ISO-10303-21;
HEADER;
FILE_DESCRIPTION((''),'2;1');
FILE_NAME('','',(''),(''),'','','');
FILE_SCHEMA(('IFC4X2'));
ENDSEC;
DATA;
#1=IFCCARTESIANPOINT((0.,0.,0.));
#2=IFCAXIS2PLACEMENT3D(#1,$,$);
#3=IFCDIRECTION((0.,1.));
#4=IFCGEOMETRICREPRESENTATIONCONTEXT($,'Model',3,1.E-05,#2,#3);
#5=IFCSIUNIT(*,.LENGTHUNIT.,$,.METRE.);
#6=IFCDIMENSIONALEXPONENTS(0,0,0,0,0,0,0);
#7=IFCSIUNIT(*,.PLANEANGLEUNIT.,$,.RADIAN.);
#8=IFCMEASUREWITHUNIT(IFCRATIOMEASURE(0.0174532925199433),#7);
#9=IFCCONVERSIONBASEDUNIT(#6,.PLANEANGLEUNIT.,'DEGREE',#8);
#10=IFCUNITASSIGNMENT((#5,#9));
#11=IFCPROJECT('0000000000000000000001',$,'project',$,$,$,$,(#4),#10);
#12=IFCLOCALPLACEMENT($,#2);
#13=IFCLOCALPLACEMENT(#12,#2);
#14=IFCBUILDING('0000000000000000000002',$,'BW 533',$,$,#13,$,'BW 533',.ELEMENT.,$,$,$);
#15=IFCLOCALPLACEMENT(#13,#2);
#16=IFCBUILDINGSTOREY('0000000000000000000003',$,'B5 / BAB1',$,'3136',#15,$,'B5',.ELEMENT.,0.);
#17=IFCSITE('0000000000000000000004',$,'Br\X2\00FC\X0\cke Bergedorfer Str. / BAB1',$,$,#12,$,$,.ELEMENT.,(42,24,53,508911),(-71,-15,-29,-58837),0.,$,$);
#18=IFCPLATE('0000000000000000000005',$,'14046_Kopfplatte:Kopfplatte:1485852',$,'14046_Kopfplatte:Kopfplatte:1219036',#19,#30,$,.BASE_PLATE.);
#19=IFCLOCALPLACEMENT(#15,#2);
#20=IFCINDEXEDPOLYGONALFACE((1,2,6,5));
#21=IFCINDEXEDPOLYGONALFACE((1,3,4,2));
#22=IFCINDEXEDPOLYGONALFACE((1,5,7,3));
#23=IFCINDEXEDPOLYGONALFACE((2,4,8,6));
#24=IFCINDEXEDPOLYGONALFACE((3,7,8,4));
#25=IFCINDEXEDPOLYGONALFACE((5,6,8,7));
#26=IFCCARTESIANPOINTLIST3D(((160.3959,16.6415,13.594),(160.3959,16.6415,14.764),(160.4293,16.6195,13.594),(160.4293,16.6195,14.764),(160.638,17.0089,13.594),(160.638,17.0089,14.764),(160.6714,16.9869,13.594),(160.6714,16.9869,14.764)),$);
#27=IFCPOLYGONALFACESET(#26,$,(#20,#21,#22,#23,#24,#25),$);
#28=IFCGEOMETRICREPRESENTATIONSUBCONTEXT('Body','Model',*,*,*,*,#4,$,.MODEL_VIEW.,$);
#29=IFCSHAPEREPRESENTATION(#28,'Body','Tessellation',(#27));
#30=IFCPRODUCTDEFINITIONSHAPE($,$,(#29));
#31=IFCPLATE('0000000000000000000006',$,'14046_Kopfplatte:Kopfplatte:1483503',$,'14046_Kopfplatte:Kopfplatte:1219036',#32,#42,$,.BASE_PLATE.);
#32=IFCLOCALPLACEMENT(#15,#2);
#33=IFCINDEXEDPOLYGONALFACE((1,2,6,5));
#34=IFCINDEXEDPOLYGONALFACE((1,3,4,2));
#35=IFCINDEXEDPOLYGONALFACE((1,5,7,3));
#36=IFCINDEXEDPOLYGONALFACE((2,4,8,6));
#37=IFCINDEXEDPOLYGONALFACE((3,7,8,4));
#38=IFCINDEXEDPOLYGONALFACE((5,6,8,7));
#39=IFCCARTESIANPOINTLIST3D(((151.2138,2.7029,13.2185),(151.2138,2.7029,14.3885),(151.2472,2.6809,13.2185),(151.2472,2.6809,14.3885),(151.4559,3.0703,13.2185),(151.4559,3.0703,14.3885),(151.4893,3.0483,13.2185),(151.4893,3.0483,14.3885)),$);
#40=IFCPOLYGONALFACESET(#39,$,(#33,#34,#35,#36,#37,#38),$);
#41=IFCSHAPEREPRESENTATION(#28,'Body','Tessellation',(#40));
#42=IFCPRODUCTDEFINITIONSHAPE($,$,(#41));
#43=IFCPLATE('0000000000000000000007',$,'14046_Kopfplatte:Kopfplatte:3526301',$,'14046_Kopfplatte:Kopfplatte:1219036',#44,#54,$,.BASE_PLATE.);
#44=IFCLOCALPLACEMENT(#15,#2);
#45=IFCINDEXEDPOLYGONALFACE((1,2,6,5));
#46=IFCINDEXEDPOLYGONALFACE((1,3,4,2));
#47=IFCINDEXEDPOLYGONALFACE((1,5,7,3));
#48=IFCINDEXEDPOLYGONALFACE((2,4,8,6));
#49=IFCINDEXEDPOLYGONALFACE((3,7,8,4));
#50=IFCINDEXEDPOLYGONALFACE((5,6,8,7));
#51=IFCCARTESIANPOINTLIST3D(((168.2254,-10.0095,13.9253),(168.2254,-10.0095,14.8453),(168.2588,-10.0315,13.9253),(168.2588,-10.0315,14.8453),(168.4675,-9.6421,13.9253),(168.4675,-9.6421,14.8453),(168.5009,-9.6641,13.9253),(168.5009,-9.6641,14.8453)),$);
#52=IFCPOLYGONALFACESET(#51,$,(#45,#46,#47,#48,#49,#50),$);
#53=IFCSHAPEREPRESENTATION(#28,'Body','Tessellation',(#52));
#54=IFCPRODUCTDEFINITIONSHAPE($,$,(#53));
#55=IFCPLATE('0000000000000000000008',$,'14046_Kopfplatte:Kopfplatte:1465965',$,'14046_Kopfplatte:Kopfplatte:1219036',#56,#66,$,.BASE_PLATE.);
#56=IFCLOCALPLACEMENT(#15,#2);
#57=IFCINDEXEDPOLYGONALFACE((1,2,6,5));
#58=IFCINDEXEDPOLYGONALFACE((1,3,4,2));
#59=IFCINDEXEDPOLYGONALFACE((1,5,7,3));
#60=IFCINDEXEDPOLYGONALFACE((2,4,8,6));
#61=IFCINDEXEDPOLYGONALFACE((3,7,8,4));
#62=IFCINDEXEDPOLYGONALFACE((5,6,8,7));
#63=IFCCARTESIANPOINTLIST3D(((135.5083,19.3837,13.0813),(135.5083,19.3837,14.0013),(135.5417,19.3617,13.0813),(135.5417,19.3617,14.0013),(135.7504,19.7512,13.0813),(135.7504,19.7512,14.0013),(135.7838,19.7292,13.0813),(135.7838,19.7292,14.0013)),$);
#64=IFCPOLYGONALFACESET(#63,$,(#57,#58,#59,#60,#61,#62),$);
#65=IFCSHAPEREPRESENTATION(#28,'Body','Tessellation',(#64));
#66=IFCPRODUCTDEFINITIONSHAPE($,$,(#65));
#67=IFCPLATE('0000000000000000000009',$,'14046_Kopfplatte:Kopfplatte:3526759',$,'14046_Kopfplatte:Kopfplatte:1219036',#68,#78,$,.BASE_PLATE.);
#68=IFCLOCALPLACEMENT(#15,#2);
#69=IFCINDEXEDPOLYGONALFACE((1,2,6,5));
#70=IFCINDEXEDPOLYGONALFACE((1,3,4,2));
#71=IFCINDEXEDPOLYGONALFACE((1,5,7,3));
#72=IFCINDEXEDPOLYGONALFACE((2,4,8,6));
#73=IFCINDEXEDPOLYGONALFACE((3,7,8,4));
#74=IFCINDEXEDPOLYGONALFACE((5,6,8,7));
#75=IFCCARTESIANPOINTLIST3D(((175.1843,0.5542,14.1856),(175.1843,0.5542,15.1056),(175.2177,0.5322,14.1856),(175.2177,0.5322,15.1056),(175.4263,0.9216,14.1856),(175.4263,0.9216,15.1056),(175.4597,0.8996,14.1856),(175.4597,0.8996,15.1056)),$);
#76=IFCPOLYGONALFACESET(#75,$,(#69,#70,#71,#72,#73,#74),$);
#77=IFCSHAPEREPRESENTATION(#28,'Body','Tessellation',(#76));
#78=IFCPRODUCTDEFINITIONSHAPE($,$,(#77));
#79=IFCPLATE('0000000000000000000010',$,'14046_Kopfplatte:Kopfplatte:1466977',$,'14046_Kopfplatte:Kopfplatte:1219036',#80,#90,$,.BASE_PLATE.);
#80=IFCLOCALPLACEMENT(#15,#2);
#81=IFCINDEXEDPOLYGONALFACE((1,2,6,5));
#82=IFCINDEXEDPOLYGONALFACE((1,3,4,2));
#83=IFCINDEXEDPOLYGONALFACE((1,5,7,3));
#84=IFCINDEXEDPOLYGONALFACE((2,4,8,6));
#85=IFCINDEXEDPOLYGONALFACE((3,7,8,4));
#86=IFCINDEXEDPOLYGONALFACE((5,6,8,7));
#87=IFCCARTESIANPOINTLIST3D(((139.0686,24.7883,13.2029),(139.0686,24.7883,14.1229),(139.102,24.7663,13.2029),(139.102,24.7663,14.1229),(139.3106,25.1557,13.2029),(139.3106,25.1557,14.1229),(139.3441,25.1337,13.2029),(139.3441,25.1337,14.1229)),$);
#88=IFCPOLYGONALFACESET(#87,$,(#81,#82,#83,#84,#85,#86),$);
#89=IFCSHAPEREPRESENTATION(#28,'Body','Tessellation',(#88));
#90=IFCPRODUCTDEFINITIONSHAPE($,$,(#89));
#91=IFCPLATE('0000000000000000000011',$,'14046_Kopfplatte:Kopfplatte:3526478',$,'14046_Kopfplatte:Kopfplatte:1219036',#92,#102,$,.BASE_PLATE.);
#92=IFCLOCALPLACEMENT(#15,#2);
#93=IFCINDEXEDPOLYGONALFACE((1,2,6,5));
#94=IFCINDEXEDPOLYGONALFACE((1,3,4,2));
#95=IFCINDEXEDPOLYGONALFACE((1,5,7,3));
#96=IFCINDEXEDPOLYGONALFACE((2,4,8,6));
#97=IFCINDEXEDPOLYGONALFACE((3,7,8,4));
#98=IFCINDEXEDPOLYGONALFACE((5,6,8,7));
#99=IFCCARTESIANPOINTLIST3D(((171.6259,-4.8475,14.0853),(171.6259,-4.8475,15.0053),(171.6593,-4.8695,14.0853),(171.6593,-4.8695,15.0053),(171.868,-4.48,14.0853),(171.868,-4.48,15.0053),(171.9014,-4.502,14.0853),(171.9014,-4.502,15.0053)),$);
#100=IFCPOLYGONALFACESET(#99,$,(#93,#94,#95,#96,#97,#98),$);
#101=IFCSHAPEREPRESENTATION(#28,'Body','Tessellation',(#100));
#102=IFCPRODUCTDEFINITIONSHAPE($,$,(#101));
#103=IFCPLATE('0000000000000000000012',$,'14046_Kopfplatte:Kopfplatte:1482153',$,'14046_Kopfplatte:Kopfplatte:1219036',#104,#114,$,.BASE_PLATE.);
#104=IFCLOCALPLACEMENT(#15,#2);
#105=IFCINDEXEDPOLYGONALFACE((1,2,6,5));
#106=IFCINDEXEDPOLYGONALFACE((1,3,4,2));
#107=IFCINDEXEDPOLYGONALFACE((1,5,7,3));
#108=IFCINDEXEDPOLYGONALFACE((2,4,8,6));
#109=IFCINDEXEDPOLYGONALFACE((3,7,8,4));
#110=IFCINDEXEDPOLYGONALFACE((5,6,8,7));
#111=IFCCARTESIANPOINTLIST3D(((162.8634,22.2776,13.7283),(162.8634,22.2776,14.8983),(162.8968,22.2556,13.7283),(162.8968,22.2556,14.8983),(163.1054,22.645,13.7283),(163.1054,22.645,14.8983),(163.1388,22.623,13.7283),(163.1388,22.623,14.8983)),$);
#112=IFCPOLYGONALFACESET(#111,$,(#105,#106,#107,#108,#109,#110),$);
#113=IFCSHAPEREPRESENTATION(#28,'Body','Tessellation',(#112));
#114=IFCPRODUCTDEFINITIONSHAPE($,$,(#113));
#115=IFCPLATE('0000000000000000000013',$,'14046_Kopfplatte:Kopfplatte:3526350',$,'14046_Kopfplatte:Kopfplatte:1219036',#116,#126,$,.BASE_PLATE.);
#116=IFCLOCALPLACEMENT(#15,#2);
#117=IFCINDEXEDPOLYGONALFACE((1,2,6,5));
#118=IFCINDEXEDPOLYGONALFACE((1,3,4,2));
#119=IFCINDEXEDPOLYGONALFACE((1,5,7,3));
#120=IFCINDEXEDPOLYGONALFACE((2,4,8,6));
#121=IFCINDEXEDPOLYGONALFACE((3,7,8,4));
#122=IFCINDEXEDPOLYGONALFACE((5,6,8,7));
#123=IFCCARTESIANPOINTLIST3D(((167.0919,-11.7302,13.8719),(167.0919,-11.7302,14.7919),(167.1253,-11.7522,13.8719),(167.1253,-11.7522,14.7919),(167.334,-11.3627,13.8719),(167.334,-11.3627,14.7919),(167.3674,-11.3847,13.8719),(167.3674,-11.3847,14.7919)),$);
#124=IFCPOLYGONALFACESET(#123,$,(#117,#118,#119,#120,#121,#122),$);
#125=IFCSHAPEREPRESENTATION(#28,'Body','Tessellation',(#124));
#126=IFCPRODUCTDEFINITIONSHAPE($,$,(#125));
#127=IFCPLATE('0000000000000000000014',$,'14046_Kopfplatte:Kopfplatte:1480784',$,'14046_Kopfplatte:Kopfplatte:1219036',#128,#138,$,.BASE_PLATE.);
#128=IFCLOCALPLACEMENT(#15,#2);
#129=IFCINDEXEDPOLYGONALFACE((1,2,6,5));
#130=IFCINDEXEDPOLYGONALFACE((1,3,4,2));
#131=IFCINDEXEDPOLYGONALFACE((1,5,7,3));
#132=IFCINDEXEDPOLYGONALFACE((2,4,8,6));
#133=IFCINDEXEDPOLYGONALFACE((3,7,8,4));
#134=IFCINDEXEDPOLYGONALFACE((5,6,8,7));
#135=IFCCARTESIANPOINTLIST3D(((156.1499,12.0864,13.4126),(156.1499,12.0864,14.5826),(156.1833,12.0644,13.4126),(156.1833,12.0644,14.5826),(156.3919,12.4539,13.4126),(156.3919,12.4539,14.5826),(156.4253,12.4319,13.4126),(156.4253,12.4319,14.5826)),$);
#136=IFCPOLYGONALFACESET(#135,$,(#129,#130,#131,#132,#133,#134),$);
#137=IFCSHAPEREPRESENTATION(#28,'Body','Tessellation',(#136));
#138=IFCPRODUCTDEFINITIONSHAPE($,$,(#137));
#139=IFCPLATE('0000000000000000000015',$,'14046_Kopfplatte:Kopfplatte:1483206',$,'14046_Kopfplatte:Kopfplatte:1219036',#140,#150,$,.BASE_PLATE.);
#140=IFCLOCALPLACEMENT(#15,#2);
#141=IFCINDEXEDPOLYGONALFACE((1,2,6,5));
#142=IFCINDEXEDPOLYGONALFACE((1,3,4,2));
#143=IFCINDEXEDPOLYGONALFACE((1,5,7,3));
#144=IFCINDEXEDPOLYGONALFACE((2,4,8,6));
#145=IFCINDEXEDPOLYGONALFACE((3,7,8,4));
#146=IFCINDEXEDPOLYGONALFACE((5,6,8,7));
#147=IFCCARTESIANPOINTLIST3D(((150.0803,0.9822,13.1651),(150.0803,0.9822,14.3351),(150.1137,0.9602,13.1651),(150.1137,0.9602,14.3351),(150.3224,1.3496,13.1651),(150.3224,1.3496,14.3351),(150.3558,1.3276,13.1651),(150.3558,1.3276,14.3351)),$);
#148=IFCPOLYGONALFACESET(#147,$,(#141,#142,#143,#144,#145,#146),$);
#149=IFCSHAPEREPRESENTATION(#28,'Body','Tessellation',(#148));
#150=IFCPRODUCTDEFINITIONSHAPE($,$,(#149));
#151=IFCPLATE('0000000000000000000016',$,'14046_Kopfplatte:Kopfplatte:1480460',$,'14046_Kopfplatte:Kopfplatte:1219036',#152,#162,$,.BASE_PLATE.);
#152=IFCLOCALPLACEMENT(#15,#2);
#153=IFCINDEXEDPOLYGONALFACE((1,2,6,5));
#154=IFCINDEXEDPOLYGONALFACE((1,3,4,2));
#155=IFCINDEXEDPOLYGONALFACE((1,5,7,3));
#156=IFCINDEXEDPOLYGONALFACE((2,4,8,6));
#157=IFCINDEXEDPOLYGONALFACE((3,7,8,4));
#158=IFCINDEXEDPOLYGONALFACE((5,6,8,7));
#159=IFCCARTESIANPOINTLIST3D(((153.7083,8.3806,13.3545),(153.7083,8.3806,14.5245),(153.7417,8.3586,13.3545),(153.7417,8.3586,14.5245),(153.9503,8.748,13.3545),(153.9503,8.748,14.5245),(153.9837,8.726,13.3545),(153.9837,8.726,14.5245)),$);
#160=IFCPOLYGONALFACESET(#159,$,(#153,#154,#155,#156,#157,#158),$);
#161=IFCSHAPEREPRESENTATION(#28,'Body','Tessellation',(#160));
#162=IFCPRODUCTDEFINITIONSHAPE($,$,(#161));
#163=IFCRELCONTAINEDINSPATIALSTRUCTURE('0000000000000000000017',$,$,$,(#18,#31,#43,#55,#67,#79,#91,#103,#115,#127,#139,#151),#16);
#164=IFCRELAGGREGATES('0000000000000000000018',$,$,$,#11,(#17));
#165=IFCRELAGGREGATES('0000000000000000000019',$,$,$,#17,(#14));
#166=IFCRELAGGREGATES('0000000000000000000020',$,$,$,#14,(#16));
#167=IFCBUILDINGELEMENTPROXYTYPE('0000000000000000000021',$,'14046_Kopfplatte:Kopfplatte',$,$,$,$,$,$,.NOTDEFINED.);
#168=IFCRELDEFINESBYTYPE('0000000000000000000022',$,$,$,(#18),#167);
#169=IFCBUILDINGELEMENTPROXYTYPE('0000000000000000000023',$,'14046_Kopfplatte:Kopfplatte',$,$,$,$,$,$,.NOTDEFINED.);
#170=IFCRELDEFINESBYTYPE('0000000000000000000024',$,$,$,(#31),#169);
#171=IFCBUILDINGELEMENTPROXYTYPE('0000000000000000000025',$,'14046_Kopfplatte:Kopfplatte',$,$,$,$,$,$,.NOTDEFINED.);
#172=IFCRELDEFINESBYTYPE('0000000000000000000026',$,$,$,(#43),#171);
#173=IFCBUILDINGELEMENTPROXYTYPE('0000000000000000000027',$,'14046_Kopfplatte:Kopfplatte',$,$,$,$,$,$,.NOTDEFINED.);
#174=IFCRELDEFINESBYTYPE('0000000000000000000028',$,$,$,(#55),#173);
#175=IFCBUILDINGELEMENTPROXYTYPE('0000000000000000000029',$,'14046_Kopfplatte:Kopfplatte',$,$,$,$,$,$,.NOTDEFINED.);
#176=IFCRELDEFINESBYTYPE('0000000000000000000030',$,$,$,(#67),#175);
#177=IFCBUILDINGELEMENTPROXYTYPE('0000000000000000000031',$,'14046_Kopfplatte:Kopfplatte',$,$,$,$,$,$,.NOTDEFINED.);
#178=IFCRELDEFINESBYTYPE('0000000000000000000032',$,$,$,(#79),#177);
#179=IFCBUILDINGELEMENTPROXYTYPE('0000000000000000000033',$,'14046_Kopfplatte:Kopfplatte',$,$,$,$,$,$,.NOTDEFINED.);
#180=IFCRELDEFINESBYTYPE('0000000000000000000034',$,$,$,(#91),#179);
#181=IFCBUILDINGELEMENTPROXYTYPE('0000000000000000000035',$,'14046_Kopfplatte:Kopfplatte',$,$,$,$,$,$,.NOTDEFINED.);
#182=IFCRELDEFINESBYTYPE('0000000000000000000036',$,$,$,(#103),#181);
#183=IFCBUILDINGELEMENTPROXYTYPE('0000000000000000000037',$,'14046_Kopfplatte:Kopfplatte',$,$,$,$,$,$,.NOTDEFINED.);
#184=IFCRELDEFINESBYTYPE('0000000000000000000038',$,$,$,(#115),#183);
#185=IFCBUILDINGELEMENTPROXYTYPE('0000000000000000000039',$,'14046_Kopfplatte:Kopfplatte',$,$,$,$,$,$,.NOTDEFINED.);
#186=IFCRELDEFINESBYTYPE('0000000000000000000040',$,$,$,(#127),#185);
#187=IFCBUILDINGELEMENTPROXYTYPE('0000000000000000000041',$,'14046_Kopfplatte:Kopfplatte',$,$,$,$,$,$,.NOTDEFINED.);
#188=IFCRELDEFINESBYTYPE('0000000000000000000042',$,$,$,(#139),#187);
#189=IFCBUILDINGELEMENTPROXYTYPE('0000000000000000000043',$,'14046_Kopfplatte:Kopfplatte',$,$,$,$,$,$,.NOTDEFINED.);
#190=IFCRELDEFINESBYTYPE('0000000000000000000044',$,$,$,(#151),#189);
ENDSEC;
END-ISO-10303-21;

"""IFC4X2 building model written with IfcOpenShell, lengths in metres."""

from ifc_helpers import new_model, entity, si_unit, converted_unit, direction, frame, frame_2d, origin, origin_2d_with_axis, place, context, subcontext, project, spatial, rectangle, extrude, source, transform, mapped, type_object, type_shapes, element, save


model = new_model("IFC4X2")

# Units and contexts
model_context = context("Model", 3, precision=1e-05, world=origin(), true_north=direction((0.0, 1.0)))
body_context = subcontext(model_context, "Body", "Model", "MODEL_VIEW")
ifc_project = project(units=[si_unit("LENGTHUNIT", "METRE"), converted_unit("PLANEANGLEUNIT", "DEGREE", entity("IfcRatioMeasure", 0.0174532925199433), si_unit("PLANEANGLEUNIT", "RADIAN"), dimensions=[0, 0, 0, 0, 0, 0, 0])], contexts=[model_context])

# Site, building, storey
site_placement = place(None, origin())
site = spatial("IfcSite", under=ifc_project, at=site_placement, Name="Brücke Bergedorfer Str. / BAB1", CompositionType="ELEMENT", RefLatitude=(42, 24, 53, 508911), RefLongitude=(-71, -15, -29, -58837), RefElevation=0.0)
building_placement = place(site_placement, origin())
building = spatial("IfcBuilding", under=site, at=building_placement, Name="BW 533", LongName="BW 533", CompositionType="ELEMENT")
storey_placement = place(building_placement, origin())
storey = spatial("IfcBuildingStorey", under=building, at=storey_placement, Name="B5 / BAB1", ObjectType="3136", LongName="B5", CompositionType="ELEMENT", Elevation=0.0)

# Plates
building_element_proxy_type_1 = type_object("IfcBuildingElementProxyType", Name="14046_Kopfplatte:Kopfplatte", PredefinedType="NOTDEFINED")
shared_shape_1 = source(origin(), body_context, "Body", "SweptSolid", [
    extrude(rectangle(XDim=0.04, YDim=0.44, at=frame_2d((0.0, 0.0), x_axis=(1.0, 0.0))), frame((160.5336, 16.8142, 13.594), z_axis=(0.0, 0.0, 1.0), x_axis=(-0.835088, 0.550116, 0.0)), (0.0, 0.0, 1.0), 1.17),
])
type_shapes(building_element_proxy_type_1, [shared_shape_1])
plate_1_placement = place(storey_placement, origin())
element("IfcPlate", 1, at=plate_1_placement, inside=storey, type_object=building_element_proxy_type_1, Name="14046_Kopfplatte:Kopfplatte:1485852", ObjectType="14046_Kopfplatte:Kopfplatte:1219036", PredefinedType="BASE_PLATE", context=body_context, shape_type="MappedRepresentation", body=[
    mapped(shared_shape_1, transform((0.0, 0.0, 0.0), scale=1.0)),
])
building_element_proxy_type_2 = type_object("IfcBuildingElementProxyType", Name="14046_Kopfplatte:Kopfplatte", PredefinedType="NOTDEFINED")
shared_shape_2 = source(origin(), body_context, "Body", "SweptSolid", [
    extrude(rectangle(XDim=0.04, YDim=0.44, at=frame_2d((0.0, 0.0), x_axis=(1.0, 0.0))), frame((151.3516, 2.8756, 13.2185), z_axis=(0.0, 0.0, 1.0), x_axis=(-0.835088, 0.550116, 0.0)), (0.0, 0.0, 1.0), 1.17),
])
type_shapes(building_element_proxy_type_2, [shared_shape_2])
plate_2_placement = place(storey_placement, origin())
element("IfcPlate", 2, at=plate_2_placement, inside=storey, type_object=building_element_proxy_type_2, Name="14046_Kopfplatte:Kopfplatte:1483503", ObjectType="14046_Kopfplatte:Kopfplatte:1219036", PredefinedType="BASE_PLATE", context=body_context, shape_type="MappedRepresentation", body=[
    mapped(shared_shape_2, transform((0.0, 0.0, 0.0), scale=1.0)),
])
building_element_proxy_type_3 = type_object("IfcBuildingElementProxyType", Name="14046_Kopfplatte:Kopfplatte", PredefinedType="NOTDEFINED")
shared_shape_3 = source(origin(), body_context, "Body", "SweptSolid", [
    extrude(rectangle(XDim=0.04, YDim=0.44, at=frame_2d((0.0, 0.0), x_axis=(1.0, 0.0))), frame((168.3631, -9.8368, 13.9253), z_axis=(0.0, 0.0, 1.0), x_axis=(0.835088, -0.550116, 0.0)), (0.0, 0.0, 1.0), 0.92),
])
type_shapes(building_element_proxy_type_3, [shared_shape_3])
plate_3_placement = place(storey_placement, origin())
element("IfcPlate", 3, at=plate_3_placement, inside=storey, type_object=building_element_proxy_type_3, Name="14046_Kopfplatte:Kopfplatte:3526301", ObjectType="14046_Kopfplatte:Kopfplatte:1219036", PredefinedType="BASE_PLATE", context=body_context, shape_type="MappedRepresentation", body=[
    mapped(shared_shape_3, transform((0.0, 0.0, 0.0), scale=1.0)),
])
building_element_proxy_type_4 = type_object("IfcBuildingElementProxyType", Name="14046_Kopfplatte:Kopfplatte", PredefinedType="NOTDEFINED")
shared_shape_4 = source(origin(), body_context, "Body", "SweptSolid", [
    extrude(rectangle(XDim=0.04, YDim=0.44, at=frame_2d((0.0, 0.0), x_axis=(1.0, 0.0))), frame((135.6461, 19.5565, 13.0813), z_axis=(0.0, 0.0, 1.0), x_axis=(-0.835088, 0.550116, 0.0)), (0.0, 0.0, 1.0), 0.92),
])
type_shapes(building_element_proxy_type_4, [shared_shape_4])
plate_4_placement = place(storey_placement, origin())
element("IfcPlate", 4, at=plate_4_placement, inside=storey, type_object=building_element_proxy_type_4, Name="14046_Kopfplatte:Kopfplatte:1465965", ObjectType="14046_Kopfplatte:Kopfplatte:1219036", PredefinedType="BASE_PLATE", context=body_context, shape_type="MappedRepresentation", body=[
    mapped(shared_shape_4, transform((0.0, 0.0, 0.0), scale=1.0)),
])
building_element_proxy_type_5 = type_object("IfcBuildingElementProxyType", Name="14046_Kopfplatte:Kopfplatte", PredefinedType="NOTDEFINED")
shared_shape_5 = source(origin(), body_context, "Body", "SweptSolid", [
    extrude(rectangle(XDim=0.04, YDim=0.44, at=frame_2d((0.0, 0.0), x_axis=(1.0, 0.0))), frame((175.322, 0.7269, 14.1856), z_axis=(0.0, 0.0, 1.0), x_axis=(0.835088, -0.550116, 0.0)), (0.0, 0.0, 1.0), 0.92),
])
type_shapes(building_element_proxy_type_5, [shared_shape_5])
plate_5_placement = place(storey_placement, origin())
element("IfcPlate", 5, at=plate_5_placement, inside=storey, type_object=building_element_proxy_type_5, Name="14046_Kopfplatte:Kopfplatte:3526759", ObjectType="14046_Kopfplatte:Kopfplatte:1219036", PredefinedType="BASE_PLATE", context=body_context, shape_type="MappedRepresentation", body=[
    mapped(shared_shape_5, transform((0.0, 0.0, 0.0), scale=1.0)),
])
building_element_proxy_type_6 = type_object("IfcBuildingElementProxyType", Name="14046_Kopfplatte:Kopfplatte", PredefinedType="NOTDEFINED")
shared_shape_6 = source(origin(), body_context, "Body", "SweptSolid", [
    extrude(rectangle(XDim=0.04, YDim=0.44, at=frame_2d((0.0, 0.0), x_axis=(1.0, 0.0))), frame((139.2063, 24.961, 13.2029), z_axis=(0.0, 0.0, 1.0), x_axis=(-0.835088, 0.550116, 0.0)), (0.0, 0.0, 1.0), 0.92),
])
type_shapes(building_element_proxy_type_6, [shared_shape_6])
plate_6_placement = place(storey_placement, origin())
element("IfcPlate", 6, at=plate_6_placement, inside=storey, type_object=building_element_proxy_type_6, Name="14046_Kopfplatte:Kopfplatte:1466977", ObjectType="14046_Kopfplatte:Kopfplatte:1219036", PredefinedType="BASE_PLATE", context=body_context, shape_type="MappedRepresentation", body=[
    mapped(shared_shape_6, transform((0.0, 0.0, 0.0), scale=1.0)),
])
building_element_proxy_type_7 = type_object("IfcBuildingElementProxyType", Name="14046_Kopfplatte:Kopfplatte", PredefinedType="NOTDEFINED")
shared_shape_7 = source(origin(), body_context, "Body", "SweptSolid", [
    extrude(rectangle(XDim=0.04, YDim=0.44, at=frame_2d((0.0, 0.0), x_axis=(1.0, 0.0))), frame((171.7636, -4.6748, 14.0853), z_axis=(0.0, 0.0, 1.0), x_axis=(0.835088, -0.550116, 0.0)), (0.0, 0.0, 1.0), 0.92),
])
type_shapes(building_element_proxy_type_7, [shared_shape_7])
plate_7_placement = place(storey_placement, origin())
element("IfcPlate", 7, at=plate_7_placement, inside=storey, type_object=building_element_proxy_type_7, Name="14046_Kopfplatte:Kopfplatte:3526478", ObjectType="14046_Kopfplatte:Kopfplatte:1219036", PredefinedType="BASE_PLATE", context=body_context, shape_type="MappedRepresentation", body=[
    mapped(shared_shape_7, transform((0.0, 0.0, 0.0), scale=1.0)),
])
building_element_proxy_type_8 = type_object("IfcBuildingElementProxyType", Name="14046_Kopfplatte:Kopfplatte", PredefinedType="NOTDEFINED")
shared_shape_8 = source(origin(), body_context, "Body", "SweptSolid", [
    extrude(rectangle(XDim=0.04, YDim=0.44, at=frame_2d((0.0, 0.0), x_axis=(1.0, 0.0))), frame((163.0011, 22.4503, 13.7283), z_axis=(0.0, 0.0, 1.0), x_axis=(0.835088, -0.550116, 0.0)), (0.0, 0.0, 1.0), 1.17),
])
type_shapes(building_element_proxy_type_8, [shared_shape_8])
plate_8_placement = place(storey_placement, origin())
element("IfcPlate", 8, at=plate_8_placement, inside=storey, type_object=building_element_proxy_type_8, Name="14046_Kopfplatte:Kopfplatte:1482153", ObjectType="14046_Kopfplatte:Kopfplatte:1219036", PredefinedType="BASE_PLATE", context=body_context, shape_type="MappedRepresentation", body=[
    mapped(shared_shape_8, transform((0.0, 0.0, 0.0), scale=1.0)),
])
building_element_proxy_type_9 = type_object("IfcBuildingElementProxyType", Name="14046_Kopfplatte:Kopfplatte", PredefinedType="NOTDEFINED")
shared_shape_9 = source(origin(), body_context, "Body", "SweptSolid", [
    extrude(rectangle(XDim=0.04, YDim=0.44, at=frame_2d((0.0, 0.0), x_axis=(1.0, 0.0))), frame((167.2296, -11.5575, 13.8719), z_axis=(0.0, 0.0, 1.0), x_axis=(0.835088, -0.550116, 0.0)), (0.0, 0.0, 1.0), 0.92),
])
type_shapes(building_element_proxy_type_9, [shared_shape_9])
plate_9_placement = place(storey_placement, origin())
element("IfcPlate", 9, at=plate_9_placement, inside=storey, type_object=building_element_proxy_type_9, Name="14046_Kopfplatte:Kopfplatte:3526350", ObjectType="14046_Kopfplatte:Kopfplatte:1219036", PredefinedType="BASE_PLATE", context=body_context, shape_type="MappedRepresentation", body=[
    mapped(shared_shape_9, transform((0.0, 0.0, 0.0), scale=1.0)),
])
building_element_proxy_type_10 = type_object("IfcBuildingElementProxyType", Name="14046_Kopfplatte:Kopfplatte", PredefinedType="NOTDEFINED")
shared_shape_10 = source(origin(), body_context, "Body", "SweptSolid", [
    extrude(rectangle(XDim=0.04, YDim=0.44, at=frame_2d((0.0, 0.0), x_axis=(1.0, 0.0))), frame((156.2876, 12.2592, 13.4126), z_axis=(0.0, 0.0, 1.0), x_axis=(0.835088, -0.550116, 0.0)), (0.0, 0.0, 1.0), 1.17),
])
type_shapes(building_element_proxy_type_10, [shared_shape_10])
plate_10_placement = place(storey_placement, origin())
element("IfcPlate", 10, at=plate_10_placement, inside=storey, type_object=building_element_proxy_type_10, Name="14046_Kopfplatte:Kopfplatte:1480784", ObjectType="14046_Kopfplatte:Kopfplatte:1219036", PredefinedType="BASE_PLATE", context=body_context, shape_type="MappedRepresentation", body=[
    mapped(shared_shape_10, transform((0.0, 0.0, 0.0), scale=1.0)),
])
building_element_proxy_type_11 = type_object("IfcBuildingElementProxyType", Name="14046_Kopfplatte:Kopfplatte", PredefinedType="NOTDEFINED")
shared_shape_11 = source(origin(), body_context, "Body", "SweptSolid", [
    extrude(rectangle(XDim=0.04, YDim=0.44, at=origin_2d_with_axis()), frame((150.2181, 1.1549, 13.1651), z_axis=(0.0, 0.0, 1.0), x_axis=(-0.835088, 0.550116, 0.0)), (0.0, 0.0, 1.0), 1.17),
])
type_shapes(building_element_proxy_type_11, [shared_shape_11])
plate_11_placement = place(storey_placement, origin())
element("IfcPlate", 11, at=plate_11_placement, inside=storey, type_object=building_element_proxy_type_11, Name="14046_Kopfplatte:Kopfplatte:1483206", ObjectType="14046_Kopfplatte:Kopfplatte:1219036", PredefinedType="BASE_PLATE", context=body_context, shape_type="MappedRepresentation", body=[
    mapped(shared_shape_11, transform((0.0, 0.0, 0.0), scale=1.0)),
])
building_element_proxy_type_12 = type_object("IfcBuildingElementProxyType", Name="14046_Kopfplatte:Kopfplatte", PredefinedType="NOTDEFINED")
shared_shape_12 = source(origin(), body_context, "Body", "SweptSolid", [
    extrude(rectangle(XDim=0.04, YDim=0.44, at=origin_2d_with_axis()), frame((153.846, 8.5533, 13.3545), z_axis=(0.0, 0.0, 1.0), x_axis=(0.835088, -0.550116, 0.0)), (0.0, 0.0, 1.0), 1.17),
])
type_shapes(building_element_proxy_type_12, [shared_shape_12])
plate_12_placement = place(storey_placement, origin())
element("IfcPlate", 12, at=plate_12_placement, inside=storey, type_object=building_element_proxy_type_12, Name="14046_Kopfplatte:Kopfplatte:1480460", ObjectType="14046_Kopfplatte:Kopfplatte:1219036", PredefinedType="BASE_PLATE", context=body_context, shape_type="MappedRepresentation", body=[
    mapped(shared_shape_12, transform((0.0, 0.0, 0.0), scale=1.0)),
])

save(model, "model.ifc")
